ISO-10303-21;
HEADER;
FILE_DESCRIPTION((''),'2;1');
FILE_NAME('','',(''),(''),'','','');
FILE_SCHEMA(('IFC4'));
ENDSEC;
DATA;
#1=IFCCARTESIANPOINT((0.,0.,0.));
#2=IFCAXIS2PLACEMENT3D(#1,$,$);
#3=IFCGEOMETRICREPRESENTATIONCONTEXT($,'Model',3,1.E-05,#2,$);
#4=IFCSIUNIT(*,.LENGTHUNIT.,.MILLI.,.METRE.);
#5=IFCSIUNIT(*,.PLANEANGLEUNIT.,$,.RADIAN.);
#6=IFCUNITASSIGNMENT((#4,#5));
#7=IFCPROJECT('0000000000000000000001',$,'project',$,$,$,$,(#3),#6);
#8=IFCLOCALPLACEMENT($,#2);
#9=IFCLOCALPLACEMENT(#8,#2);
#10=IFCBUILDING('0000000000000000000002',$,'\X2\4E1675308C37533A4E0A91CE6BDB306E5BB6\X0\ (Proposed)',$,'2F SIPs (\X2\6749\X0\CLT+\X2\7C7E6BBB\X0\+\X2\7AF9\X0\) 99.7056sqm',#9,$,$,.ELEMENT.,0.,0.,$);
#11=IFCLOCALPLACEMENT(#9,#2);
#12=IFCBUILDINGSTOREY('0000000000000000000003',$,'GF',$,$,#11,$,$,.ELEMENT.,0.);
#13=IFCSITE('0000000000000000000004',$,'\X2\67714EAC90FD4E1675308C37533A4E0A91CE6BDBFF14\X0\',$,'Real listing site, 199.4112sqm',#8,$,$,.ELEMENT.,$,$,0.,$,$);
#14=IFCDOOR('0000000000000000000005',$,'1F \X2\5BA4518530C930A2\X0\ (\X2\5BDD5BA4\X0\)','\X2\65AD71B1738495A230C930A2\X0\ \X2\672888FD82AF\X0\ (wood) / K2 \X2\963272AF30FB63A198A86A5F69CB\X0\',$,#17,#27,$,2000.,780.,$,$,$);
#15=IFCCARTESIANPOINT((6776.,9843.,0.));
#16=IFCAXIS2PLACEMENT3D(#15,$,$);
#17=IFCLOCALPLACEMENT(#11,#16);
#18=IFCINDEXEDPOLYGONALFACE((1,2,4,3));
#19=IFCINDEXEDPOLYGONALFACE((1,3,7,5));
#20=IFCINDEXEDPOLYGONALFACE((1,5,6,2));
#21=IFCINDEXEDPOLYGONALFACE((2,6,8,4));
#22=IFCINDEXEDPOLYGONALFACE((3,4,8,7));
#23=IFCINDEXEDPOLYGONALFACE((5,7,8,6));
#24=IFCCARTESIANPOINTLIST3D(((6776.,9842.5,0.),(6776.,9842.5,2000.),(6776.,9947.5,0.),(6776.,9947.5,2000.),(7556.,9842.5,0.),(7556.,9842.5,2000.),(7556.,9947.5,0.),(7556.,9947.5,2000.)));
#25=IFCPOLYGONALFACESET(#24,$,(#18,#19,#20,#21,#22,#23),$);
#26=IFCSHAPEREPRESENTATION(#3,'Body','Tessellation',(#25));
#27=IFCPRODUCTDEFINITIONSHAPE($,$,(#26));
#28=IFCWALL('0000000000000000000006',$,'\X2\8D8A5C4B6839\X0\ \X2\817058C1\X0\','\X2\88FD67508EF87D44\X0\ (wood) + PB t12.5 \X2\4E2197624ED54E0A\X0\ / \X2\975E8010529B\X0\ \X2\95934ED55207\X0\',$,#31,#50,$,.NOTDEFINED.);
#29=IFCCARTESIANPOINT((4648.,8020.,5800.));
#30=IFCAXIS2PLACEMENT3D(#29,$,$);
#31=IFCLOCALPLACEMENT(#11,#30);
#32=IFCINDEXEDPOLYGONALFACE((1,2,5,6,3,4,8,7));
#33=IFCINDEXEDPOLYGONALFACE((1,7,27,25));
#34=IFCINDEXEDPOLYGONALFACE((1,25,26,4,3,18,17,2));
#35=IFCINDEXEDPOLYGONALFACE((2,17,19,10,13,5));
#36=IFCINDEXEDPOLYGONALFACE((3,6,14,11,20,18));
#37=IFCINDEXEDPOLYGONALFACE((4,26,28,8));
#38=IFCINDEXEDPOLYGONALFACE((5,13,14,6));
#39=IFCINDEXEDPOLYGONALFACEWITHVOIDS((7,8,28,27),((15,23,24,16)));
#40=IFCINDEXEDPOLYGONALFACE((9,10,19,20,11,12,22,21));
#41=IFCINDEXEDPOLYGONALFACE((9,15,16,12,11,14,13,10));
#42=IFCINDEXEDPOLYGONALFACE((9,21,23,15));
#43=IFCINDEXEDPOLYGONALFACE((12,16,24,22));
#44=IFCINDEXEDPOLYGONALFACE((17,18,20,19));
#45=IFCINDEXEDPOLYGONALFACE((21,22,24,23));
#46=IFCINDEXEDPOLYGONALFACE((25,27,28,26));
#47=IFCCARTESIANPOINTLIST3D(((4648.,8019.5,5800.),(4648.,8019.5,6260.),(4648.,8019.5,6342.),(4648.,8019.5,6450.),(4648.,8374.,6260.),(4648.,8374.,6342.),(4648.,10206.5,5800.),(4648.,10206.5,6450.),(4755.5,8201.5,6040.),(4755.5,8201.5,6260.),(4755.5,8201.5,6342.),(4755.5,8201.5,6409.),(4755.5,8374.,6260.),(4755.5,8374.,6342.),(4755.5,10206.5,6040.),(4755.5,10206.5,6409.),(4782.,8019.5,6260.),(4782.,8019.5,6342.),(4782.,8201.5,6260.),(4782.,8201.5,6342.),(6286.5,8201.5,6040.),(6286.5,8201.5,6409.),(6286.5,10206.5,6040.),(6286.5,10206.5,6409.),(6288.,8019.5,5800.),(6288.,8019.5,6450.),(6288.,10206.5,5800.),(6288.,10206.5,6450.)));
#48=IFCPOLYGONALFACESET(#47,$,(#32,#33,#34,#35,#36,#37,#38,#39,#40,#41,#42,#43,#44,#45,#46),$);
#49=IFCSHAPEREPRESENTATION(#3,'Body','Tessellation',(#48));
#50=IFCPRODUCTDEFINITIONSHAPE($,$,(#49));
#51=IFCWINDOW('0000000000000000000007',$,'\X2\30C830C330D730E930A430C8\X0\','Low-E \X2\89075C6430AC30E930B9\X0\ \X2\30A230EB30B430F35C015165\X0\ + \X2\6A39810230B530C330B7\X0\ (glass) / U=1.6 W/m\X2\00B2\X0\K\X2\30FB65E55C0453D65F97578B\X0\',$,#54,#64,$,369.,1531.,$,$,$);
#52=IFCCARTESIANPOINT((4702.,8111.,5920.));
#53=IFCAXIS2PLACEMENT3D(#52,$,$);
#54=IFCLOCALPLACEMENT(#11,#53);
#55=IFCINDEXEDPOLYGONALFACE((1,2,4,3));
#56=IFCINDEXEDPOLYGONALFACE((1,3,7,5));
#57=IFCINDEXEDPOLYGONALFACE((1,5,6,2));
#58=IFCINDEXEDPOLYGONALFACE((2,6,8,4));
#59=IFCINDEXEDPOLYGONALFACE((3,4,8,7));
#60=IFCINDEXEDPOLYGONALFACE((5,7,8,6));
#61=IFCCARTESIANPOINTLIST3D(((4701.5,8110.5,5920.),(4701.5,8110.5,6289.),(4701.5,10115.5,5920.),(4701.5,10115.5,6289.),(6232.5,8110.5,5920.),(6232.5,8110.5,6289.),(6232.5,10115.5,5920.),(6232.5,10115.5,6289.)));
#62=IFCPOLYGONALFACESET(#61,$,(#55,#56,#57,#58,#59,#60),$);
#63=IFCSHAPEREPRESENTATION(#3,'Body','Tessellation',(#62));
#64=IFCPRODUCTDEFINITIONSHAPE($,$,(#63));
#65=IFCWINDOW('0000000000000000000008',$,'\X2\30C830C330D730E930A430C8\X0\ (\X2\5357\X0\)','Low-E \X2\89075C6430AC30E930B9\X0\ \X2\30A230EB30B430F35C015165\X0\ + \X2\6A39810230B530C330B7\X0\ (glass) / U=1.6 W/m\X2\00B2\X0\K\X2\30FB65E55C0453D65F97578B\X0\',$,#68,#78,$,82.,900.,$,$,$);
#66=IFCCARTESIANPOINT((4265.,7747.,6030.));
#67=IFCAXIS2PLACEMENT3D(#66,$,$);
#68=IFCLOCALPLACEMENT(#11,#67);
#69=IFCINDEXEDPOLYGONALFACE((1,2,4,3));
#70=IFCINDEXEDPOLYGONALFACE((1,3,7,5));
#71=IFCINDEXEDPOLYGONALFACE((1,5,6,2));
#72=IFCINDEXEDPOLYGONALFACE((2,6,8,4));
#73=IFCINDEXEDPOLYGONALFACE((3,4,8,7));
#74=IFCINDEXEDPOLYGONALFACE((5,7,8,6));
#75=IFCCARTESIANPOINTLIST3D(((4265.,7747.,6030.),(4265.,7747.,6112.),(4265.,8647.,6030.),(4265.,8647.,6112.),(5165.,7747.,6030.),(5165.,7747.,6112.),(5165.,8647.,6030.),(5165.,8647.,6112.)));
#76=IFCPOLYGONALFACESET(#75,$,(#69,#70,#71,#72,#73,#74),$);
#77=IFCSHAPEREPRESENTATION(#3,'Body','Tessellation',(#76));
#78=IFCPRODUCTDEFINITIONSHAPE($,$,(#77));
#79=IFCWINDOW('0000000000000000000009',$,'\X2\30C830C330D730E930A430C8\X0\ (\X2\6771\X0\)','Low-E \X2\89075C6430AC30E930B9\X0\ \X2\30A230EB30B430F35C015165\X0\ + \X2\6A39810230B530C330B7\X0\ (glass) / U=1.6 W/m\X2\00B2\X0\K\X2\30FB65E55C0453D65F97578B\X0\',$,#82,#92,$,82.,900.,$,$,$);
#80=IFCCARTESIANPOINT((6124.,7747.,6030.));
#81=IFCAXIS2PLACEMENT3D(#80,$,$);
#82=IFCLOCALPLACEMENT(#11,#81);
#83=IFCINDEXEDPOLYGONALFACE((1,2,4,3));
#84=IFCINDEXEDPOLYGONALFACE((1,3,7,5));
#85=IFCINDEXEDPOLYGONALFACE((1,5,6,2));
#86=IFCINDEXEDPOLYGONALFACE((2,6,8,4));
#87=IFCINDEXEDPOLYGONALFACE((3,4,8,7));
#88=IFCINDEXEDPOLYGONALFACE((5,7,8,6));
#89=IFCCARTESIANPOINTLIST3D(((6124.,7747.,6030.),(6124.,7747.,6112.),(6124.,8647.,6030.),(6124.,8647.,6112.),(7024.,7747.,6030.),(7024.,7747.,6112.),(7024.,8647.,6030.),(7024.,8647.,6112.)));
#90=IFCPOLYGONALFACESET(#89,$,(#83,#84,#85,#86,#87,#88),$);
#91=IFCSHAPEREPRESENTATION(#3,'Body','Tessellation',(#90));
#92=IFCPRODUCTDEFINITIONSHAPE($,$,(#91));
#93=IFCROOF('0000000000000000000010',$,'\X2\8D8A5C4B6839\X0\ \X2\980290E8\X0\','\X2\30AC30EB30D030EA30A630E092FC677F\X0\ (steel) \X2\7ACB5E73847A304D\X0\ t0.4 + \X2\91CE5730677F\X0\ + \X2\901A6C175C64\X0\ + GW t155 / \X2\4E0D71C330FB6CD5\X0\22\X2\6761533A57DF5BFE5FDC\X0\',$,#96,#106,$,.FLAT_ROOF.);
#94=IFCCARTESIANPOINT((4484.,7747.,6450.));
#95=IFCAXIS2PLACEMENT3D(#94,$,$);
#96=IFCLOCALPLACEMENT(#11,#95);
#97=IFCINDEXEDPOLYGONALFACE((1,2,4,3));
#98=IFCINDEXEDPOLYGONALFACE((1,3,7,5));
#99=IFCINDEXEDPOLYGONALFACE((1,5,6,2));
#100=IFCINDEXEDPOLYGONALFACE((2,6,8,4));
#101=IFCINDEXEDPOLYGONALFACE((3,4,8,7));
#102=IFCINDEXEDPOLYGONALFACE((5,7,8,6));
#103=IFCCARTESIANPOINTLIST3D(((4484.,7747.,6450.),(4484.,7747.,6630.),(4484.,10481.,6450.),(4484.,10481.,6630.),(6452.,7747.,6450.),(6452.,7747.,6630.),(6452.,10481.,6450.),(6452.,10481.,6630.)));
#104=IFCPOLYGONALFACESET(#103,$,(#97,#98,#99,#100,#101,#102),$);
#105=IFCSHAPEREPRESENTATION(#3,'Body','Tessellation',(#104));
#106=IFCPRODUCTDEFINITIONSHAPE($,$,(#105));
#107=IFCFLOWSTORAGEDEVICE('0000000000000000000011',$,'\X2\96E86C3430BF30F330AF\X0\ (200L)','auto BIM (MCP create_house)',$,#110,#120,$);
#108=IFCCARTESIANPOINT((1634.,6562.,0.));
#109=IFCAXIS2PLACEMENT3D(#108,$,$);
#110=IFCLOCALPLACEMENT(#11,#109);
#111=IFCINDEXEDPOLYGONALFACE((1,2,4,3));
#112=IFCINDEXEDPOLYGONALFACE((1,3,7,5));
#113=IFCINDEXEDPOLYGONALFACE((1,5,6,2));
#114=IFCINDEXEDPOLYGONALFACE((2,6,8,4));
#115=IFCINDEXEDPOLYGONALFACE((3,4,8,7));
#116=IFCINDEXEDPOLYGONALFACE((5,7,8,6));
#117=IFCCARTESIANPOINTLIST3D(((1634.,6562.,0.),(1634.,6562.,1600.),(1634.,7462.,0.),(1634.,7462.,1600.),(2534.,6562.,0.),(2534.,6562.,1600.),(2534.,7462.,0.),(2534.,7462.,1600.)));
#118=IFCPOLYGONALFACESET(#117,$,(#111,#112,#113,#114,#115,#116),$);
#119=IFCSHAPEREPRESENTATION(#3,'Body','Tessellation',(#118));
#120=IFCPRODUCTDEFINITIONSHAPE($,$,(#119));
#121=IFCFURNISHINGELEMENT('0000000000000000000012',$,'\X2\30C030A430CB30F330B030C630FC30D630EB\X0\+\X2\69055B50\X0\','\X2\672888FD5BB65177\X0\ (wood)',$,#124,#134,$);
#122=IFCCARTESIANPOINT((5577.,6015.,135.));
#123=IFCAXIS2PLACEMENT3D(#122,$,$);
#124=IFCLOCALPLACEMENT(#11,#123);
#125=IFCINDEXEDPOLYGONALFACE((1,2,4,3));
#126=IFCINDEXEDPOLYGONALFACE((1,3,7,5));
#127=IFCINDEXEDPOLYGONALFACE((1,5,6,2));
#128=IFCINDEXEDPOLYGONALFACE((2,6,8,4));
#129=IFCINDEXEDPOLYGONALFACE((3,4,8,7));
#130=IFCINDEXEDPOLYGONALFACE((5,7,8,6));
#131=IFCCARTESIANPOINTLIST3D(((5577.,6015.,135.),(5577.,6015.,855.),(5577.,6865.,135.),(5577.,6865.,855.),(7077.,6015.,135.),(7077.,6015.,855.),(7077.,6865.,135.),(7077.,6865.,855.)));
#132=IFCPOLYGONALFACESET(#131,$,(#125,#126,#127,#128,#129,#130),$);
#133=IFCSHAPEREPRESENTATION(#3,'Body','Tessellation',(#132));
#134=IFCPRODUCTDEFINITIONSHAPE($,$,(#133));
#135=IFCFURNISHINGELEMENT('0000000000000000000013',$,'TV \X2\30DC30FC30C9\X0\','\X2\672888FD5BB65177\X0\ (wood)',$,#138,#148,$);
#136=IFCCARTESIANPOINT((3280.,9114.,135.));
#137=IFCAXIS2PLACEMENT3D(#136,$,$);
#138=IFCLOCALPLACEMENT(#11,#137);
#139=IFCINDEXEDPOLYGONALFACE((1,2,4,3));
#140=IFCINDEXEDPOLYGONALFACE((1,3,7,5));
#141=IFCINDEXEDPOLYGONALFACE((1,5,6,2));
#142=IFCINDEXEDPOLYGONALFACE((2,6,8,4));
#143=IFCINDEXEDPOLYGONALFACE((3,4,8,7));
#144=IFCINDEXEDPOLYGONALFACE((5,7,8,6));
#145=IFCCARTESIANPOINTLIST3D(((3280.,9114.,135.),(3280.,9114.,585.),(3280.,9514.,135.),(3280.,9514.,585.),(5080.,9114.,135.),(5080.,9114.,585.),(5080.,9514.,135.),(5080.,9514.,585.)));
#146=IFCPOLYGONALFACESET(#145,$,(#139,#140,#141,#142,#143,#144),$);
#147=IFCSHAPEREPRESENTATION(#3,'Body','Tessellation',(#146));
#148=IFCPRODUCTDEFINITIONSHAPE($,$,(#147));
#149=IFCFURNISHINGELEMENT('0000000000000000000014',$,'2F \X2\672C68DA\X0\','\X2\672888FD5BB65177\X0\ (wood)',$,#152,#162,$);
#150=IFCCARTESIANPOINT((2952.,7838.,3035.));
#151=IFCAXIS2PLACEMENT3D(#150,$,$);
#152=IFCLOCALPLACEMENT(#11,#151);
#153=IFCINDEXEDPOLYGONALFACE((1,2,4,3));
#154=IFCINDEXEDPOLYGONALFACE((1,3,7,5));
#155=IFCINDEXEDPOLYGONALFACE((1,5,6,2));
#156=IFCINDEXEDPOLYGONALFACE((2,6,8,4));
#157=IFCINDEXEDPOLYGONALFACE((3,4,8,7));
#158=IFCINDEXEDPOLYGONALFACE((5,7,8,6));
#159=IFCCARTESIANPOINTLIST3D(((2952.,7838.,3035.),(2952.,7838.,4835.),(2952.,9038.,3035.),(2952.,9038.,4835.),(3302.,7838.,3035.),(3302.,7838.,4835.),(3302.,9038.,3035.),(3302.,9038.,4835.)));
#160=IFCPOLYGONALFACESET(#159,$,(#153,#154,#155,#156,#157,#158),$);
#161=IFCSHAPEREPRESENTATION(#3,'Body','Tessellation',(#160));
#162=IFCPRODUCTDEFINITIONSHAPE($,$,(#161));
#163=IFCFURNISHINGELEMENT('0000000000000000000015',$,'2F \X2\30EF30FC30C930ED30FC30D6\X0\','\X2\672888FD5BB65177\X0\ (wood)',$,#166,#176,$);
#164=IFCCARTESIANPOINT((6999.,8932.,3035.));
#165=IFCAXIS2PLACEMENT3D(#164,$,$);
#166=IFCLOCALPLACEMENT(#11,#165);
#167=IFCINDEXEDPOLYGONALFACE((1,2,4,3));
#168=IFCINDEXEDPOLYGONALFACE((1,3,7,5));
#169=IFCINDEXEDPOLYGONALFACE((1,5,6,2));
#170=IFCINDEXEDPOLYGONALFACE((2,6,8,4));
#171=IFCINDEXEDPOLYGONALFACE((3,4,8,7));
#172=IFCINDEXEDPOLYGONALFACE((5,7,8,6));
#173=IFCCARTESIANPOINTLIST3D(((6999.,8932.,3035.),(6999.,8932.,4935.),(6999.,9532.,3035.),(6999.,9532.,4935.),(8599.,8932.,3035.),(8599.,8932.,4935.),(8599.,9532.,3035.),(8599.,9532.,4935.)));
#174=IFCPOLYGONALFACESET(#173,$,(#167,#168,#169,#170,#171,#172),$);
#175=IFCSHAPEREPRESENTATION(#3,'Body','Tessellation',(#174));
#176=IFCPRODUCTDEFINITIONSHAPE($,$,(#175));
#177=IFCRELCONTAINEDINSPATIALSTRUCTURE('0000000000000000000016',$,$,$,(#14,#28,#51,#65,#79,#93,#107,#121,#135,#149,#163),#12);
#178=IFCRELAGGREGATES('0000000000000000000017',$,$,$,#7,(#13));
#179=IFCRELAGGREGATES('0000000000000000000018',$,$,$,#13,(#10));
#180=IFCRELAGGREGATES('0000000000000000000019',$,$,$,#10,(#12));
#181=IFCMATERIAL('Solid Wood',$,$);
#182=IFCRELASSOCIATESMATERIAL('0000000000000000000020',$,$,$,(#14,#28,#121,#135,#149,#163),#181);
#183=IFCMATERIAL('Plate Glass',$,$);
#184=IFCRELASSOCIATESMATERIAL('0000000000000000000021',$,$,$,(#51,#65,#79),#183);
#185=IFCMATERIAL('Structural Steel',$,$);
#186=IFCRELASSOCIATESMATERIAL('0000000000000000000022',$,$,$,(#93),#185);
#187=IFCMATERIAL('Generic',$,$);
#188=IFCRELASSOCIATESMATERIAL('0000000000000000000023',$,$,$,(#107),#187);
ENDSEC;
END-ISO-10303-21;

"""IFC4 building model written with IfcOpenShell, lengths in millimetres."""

from ifc_helpers import new_model, si_unit, frame, frame_2d, origin, place, context, project, spatial, rectangle, extrude, material, element, fill, save


model = new_model("IFC4")

# Units and contexts
model_context = context("Model", 3, precision=1e-05, world=origin())
ifc_project = project(units=[si_unit("LENGTHUNIT", "METRE", prefix="MILLI"), si_unit("PLANEANGLEUNIT", "RADIAN")], contexts=[model_context])

# Site, building, storey
site_placement = place(None, origin())
site = spatial("IfcSite", under=ifc_project, at=site_placement, Name="東京都世田谷区上野毛４", ObjectType="Real listing site, 199.4112sqm", CompositionType="ELEMENT", RefElevation=0.0)
building_placement = place(site_placement, origin())
building = spatial("IfcBuilding", under=site, at=building_placement, Name="世田谷区上野毛の家 (Proposed)", ObjectType="2F SIPs (杉CLT+籾殻+竹) 99.7056sqm", CompositionType="ELEMENT", ElevationOfRefHeight=0.0, ElevationOfTerrain=0.0)
storey_placement = place(building_placement, origin())
storey = spatial("IfcBuildingStorey", under=building, at=storey_placement, Name="GF", CompositionType="ELEMENT", Elevation=0.0)

# Shared definitions
ifc_material_1 = material(Name="Solid Wood")

# Door
door_placement = place(storey_placement, frame((6776.0, 9843.0, 0.0)))
element("IfcDoor", 1, at=door_placement, inside=storey, material=ifc_material_1, Name="1F 室内ドア (寝室)", Description="断熱玄関ドア 木製芯 (wood) / K2 防犯・採風機構", OverallHeight=2000.0, OverallWidth=780.0, context=model_context, shape_type="SweptSolid", body=[
    extrude(rectangle(XDim=780.0, YDim=105.0, at=frame_2d((390.0, 52.0))), frame((6776.0, 9843.0, 0.0)), (0.0, 0.0, 1.0), 2000.0),
])

# Wall, openings, windows
wall_1_placement = place(storey_placement, frame((4648.0, 8020.0, 5800.0)))
wall_1 = element("IfcWall", 2, at=wall_1_placement, inside=storey, material=ifc_material_1, Name="越屋根 腰壁", Description="製材軸組 (wood) + PB t12.5 両面仕上 / 非耐力 間仕切", PredefinedType="NOTDEFINED", context=model_context, shape_type="SweptSolid", body=[
    extrude(rectangle(XDim=1640.0, YDim=2187.0, at=frame_2d((820.0, 1093.0))), frame((4648.0, 8020.0, 5800.0)), (0.0, 0.0, 1.0), 650.0),
])
opening_1_placement = place(storey_placement, frame((4702.0, 8111.0, 5920.0)))
opening_1 = element("IfcOpeningElement", 3, at=opening_1_placement, cuts=wall_1, PredefinedType="NOTDEFINED", context=model_context, shape_type="SweptSolid", body=[
    extrude(rectangle(XDim=1531.0, YDim=2005.0, at=frame_2d((765.0, 1002.0))), frame((4702.0, 8111.0, 5920.0)), (0.0, 0.0, 1.0), 369.0),
])
opening_2_placement = place(storey_placement, frame((4265.0, 7747.0, 6030.0)))
opening_2 = element("IfcOpeningElement", 4, at=opening_2_placement, cuts=wall_1, PredefinedType="NOTDEFINED", context=model_context, shape_type="SweptSolid", body=[
    extrude(rectangle(XDim=900.0, YDim=900.0, at=frame_2d((450.0, 450.0))), frame((4265.0, 7747.0, 6030.0)), (0.0, 0.0, 1.0), 82.0),
])
opening_3_placement = place(storey_placement, frame((6124.0, 7747.0, 6030.0)))
opening_3 = element("IfcOpeningElement", 5, at=opening_3_placement, cuts=wall_1, PredefinedType="NOTDEFINED", context=model_context, shape_type="SweptSolid", body=[
    extrude(rectangle(XDim=900.0, YDim=900.0, at=frame_2d((450.0, 450.0))), frame((6124.0, 7747.0, 6030.0)), (0.0, 0.0, 1.0), 82.0),
])
ifc_material_2 = material(Name="Plate Glass")
window_1_placement = place(storey_placement, frame((4702.0, 8111.0, 5920.0)))
window_1 = element("IfcWindow", 6, at=window_1_placement, inside=storey, material=ifc_material_2, Name="トップライト", Description="Low-E 複層ガラス アルゴン封入 + 樹脂サッシ (glass) / U=1.6 W/m²K・日射取得型", OverallHeight=369.0, OverallWidth=1531.0, context=model_context, shape_type="SweptSolid", body=[
    extrude(rectangle(XDim=1531.0, YDim=2005.0, at=frame_2d((765.0, 1002.0))), frame((4702.0, 8111.0, 5920.0)), (0.0, 0.0, 1.0), 369.0),
])
fill(opening_1, window_1)
window_2_placement = place(storey_placement, frame((4265.0, 7747.0, 6030.0)))
window_2 = element("IfcWindow", 7, at=window_2_placement, inside=storey, material=ifc_material_2, Name="トップライト (南)", Description="Low-E 複層ガラス アルゴン封入 + 樹脂サッシ (glass) / U=1.6 W/m²K・日射取得型", OverallHeight=82.0, OverallWidth=900.0, context=model_context, shape_type="SweptSolid", body=[
    extrude(rectangle(XDim=900.0, YDim=900.0, at=frame_2d((450.0, 450.0))), frame((4265.0, 7747.0, 6030.0)), (0.0, 0.0, 1.0), 82.0),
])
fill(opening_2, window_2)
window_3_placement = place(storey_placement, frame((6124.0, 7747.0, 6030.0)))
window_3 = element("IfcWindow", 8, at=window_3_placement, inside=storey, material=ifc_material_2, Name="トップライト (東)", Description="Low-E 複層ガラス アルゴン封入 + 樹脂サッシ (glass) / U=1.6 W/m²K・日射取得型", OverallHeight=82.0, OverallWidth=900.0, context=model_context, shape_type="SweptSolid", body=[
    extrude(rectangle(XDim=900.0, YDim=900.0, at=frame_2d((450.0, 450.0))), frame((6124.0, 7747.0, 6030.0)), (0.0, 0.0, 1.0), 82.0),
])
fill(opening_3, window_3)

# Roof
ifc_material_3 = material(Name="Structural Steel")
roof_placement = place(storey_placement, frame((4484.0, 7747.0, 6450.0)))
element("IfcRoof", 9, at=roof_placement, inside=storey, material=ifc_material_3, Name="越屋根 頂部", Description="ガルバリウム鋼板 (steel) 立平葺き t0.4 + 野地板 + 通気層 + GW t155 / 不燃・法22条区域対応", PredefinedType="FLAT_ROOF", context=model_context, shape_type="SweptSolid", body=[
    extrude(rectangle(XDim=1968.0, YDim=2734.0, at=frame_2d((984.0, 1367.0))), frame((4484.0, 7747.0, 6450.0)), (0.0, 0.0, 1.0), 180.0),
])

# Flow storage device
ifc_material_4 = material(Name="Generic")
flow_storage_device_placement = place(storey_placement, frame((1634.0, 6562.0, 0.0)))
element("IfcFlowStorageDevice", 10, at=flow_storage_device_placement, inside=storey, material=ifc_material_4, Name="雨水タンク (200L)", Description="auto BIM (MCP create_house)", context=model_context, shape_type="SweptSolid", body=[
    extrude(rectangle(XDim=900.0, YDim=900.0, at=frame_2d((450.0, 450.0))), frame((1634.0, 6562.0, 0.0)), (0.0, 0.0, 1.0), 1600.0),
])

# Furnishing elements
furnishing_1_placement = place(storey_placement, frame((5577.0, 6015.0, 135.0)))
element("IfcFurnishingElement", 11, at=furnishing_1_placement, inside=storey, material=ifc_material_1, Name="ダイニングテーブル+椅子", Description="木製家具 (wood)", context=model_context, shape_type="SweptSolid", body=[
    extrude(rectangle(XDim=1500.0, YDim=850.0, at=frame_2d((750.0, 425.0))), frame((5577.0, 6015.0, 135.0)), (0.0, 0.0, 1.0), 720.0),
])
furnishing_2_placement = place(storey_placement, frame((3280.0, 9114.0, 135.0)))
element("IfcFurnishingElement", 12, at=furnishing_2_placement, inside=storey, material=ifc_material_1, Name="TV ボード", Description="木製家具 (wood)", context=model_context, shape_type="SweptSolid", body=[
    extrude(rectangle(XDim=1800.0, YDim=400.0, at=frame_2d((900.0, 200.0))), frame((3280.0, 9114.0, 135.0)), (0.0, 0.0, 1.0), 450.0),
])
furnishing_3_placement = place(storey_placement, frame((2952.0, 7838.0, 3035.0)))
element("IfcFurnishingElement", 13, at=furnishing_3_placement, inside=storey, material=ifc_material_1, Name="2F 本棚", Description="木製家具 (wood)", context=model_context, shape_type="SweptSolid", body=[
    extrude(rectangle(XDim=350.0, YDim=1200.0, at=frame_2d((175.0, 600.0))), frame((2952.0, 7838.0, 3035.0)), (0.0, 0.0, 1.0), 1800.0),
])
furnishing_4_placement = place(storey_placement, frame((6999.0, 8932.0, 3035.0)))
element("IfcFurnishingElement", 14, at=furnishing_4_placement, inside=storey, material=ifc_material_1, Name="2F ワードローブ", Description="木製家具 (wood)", context=model_context, shape_type="SweptSolid", body=[
    extrude(rectangle(XDim=1600.0, YDim=600.0, at=frame_2d((800.0, 300.0))), frame((6999.0, 8932.0, 3035.0)), (0.0, 0.0, 1.0), 1900.0),
])

save(model, "model.ifc")
